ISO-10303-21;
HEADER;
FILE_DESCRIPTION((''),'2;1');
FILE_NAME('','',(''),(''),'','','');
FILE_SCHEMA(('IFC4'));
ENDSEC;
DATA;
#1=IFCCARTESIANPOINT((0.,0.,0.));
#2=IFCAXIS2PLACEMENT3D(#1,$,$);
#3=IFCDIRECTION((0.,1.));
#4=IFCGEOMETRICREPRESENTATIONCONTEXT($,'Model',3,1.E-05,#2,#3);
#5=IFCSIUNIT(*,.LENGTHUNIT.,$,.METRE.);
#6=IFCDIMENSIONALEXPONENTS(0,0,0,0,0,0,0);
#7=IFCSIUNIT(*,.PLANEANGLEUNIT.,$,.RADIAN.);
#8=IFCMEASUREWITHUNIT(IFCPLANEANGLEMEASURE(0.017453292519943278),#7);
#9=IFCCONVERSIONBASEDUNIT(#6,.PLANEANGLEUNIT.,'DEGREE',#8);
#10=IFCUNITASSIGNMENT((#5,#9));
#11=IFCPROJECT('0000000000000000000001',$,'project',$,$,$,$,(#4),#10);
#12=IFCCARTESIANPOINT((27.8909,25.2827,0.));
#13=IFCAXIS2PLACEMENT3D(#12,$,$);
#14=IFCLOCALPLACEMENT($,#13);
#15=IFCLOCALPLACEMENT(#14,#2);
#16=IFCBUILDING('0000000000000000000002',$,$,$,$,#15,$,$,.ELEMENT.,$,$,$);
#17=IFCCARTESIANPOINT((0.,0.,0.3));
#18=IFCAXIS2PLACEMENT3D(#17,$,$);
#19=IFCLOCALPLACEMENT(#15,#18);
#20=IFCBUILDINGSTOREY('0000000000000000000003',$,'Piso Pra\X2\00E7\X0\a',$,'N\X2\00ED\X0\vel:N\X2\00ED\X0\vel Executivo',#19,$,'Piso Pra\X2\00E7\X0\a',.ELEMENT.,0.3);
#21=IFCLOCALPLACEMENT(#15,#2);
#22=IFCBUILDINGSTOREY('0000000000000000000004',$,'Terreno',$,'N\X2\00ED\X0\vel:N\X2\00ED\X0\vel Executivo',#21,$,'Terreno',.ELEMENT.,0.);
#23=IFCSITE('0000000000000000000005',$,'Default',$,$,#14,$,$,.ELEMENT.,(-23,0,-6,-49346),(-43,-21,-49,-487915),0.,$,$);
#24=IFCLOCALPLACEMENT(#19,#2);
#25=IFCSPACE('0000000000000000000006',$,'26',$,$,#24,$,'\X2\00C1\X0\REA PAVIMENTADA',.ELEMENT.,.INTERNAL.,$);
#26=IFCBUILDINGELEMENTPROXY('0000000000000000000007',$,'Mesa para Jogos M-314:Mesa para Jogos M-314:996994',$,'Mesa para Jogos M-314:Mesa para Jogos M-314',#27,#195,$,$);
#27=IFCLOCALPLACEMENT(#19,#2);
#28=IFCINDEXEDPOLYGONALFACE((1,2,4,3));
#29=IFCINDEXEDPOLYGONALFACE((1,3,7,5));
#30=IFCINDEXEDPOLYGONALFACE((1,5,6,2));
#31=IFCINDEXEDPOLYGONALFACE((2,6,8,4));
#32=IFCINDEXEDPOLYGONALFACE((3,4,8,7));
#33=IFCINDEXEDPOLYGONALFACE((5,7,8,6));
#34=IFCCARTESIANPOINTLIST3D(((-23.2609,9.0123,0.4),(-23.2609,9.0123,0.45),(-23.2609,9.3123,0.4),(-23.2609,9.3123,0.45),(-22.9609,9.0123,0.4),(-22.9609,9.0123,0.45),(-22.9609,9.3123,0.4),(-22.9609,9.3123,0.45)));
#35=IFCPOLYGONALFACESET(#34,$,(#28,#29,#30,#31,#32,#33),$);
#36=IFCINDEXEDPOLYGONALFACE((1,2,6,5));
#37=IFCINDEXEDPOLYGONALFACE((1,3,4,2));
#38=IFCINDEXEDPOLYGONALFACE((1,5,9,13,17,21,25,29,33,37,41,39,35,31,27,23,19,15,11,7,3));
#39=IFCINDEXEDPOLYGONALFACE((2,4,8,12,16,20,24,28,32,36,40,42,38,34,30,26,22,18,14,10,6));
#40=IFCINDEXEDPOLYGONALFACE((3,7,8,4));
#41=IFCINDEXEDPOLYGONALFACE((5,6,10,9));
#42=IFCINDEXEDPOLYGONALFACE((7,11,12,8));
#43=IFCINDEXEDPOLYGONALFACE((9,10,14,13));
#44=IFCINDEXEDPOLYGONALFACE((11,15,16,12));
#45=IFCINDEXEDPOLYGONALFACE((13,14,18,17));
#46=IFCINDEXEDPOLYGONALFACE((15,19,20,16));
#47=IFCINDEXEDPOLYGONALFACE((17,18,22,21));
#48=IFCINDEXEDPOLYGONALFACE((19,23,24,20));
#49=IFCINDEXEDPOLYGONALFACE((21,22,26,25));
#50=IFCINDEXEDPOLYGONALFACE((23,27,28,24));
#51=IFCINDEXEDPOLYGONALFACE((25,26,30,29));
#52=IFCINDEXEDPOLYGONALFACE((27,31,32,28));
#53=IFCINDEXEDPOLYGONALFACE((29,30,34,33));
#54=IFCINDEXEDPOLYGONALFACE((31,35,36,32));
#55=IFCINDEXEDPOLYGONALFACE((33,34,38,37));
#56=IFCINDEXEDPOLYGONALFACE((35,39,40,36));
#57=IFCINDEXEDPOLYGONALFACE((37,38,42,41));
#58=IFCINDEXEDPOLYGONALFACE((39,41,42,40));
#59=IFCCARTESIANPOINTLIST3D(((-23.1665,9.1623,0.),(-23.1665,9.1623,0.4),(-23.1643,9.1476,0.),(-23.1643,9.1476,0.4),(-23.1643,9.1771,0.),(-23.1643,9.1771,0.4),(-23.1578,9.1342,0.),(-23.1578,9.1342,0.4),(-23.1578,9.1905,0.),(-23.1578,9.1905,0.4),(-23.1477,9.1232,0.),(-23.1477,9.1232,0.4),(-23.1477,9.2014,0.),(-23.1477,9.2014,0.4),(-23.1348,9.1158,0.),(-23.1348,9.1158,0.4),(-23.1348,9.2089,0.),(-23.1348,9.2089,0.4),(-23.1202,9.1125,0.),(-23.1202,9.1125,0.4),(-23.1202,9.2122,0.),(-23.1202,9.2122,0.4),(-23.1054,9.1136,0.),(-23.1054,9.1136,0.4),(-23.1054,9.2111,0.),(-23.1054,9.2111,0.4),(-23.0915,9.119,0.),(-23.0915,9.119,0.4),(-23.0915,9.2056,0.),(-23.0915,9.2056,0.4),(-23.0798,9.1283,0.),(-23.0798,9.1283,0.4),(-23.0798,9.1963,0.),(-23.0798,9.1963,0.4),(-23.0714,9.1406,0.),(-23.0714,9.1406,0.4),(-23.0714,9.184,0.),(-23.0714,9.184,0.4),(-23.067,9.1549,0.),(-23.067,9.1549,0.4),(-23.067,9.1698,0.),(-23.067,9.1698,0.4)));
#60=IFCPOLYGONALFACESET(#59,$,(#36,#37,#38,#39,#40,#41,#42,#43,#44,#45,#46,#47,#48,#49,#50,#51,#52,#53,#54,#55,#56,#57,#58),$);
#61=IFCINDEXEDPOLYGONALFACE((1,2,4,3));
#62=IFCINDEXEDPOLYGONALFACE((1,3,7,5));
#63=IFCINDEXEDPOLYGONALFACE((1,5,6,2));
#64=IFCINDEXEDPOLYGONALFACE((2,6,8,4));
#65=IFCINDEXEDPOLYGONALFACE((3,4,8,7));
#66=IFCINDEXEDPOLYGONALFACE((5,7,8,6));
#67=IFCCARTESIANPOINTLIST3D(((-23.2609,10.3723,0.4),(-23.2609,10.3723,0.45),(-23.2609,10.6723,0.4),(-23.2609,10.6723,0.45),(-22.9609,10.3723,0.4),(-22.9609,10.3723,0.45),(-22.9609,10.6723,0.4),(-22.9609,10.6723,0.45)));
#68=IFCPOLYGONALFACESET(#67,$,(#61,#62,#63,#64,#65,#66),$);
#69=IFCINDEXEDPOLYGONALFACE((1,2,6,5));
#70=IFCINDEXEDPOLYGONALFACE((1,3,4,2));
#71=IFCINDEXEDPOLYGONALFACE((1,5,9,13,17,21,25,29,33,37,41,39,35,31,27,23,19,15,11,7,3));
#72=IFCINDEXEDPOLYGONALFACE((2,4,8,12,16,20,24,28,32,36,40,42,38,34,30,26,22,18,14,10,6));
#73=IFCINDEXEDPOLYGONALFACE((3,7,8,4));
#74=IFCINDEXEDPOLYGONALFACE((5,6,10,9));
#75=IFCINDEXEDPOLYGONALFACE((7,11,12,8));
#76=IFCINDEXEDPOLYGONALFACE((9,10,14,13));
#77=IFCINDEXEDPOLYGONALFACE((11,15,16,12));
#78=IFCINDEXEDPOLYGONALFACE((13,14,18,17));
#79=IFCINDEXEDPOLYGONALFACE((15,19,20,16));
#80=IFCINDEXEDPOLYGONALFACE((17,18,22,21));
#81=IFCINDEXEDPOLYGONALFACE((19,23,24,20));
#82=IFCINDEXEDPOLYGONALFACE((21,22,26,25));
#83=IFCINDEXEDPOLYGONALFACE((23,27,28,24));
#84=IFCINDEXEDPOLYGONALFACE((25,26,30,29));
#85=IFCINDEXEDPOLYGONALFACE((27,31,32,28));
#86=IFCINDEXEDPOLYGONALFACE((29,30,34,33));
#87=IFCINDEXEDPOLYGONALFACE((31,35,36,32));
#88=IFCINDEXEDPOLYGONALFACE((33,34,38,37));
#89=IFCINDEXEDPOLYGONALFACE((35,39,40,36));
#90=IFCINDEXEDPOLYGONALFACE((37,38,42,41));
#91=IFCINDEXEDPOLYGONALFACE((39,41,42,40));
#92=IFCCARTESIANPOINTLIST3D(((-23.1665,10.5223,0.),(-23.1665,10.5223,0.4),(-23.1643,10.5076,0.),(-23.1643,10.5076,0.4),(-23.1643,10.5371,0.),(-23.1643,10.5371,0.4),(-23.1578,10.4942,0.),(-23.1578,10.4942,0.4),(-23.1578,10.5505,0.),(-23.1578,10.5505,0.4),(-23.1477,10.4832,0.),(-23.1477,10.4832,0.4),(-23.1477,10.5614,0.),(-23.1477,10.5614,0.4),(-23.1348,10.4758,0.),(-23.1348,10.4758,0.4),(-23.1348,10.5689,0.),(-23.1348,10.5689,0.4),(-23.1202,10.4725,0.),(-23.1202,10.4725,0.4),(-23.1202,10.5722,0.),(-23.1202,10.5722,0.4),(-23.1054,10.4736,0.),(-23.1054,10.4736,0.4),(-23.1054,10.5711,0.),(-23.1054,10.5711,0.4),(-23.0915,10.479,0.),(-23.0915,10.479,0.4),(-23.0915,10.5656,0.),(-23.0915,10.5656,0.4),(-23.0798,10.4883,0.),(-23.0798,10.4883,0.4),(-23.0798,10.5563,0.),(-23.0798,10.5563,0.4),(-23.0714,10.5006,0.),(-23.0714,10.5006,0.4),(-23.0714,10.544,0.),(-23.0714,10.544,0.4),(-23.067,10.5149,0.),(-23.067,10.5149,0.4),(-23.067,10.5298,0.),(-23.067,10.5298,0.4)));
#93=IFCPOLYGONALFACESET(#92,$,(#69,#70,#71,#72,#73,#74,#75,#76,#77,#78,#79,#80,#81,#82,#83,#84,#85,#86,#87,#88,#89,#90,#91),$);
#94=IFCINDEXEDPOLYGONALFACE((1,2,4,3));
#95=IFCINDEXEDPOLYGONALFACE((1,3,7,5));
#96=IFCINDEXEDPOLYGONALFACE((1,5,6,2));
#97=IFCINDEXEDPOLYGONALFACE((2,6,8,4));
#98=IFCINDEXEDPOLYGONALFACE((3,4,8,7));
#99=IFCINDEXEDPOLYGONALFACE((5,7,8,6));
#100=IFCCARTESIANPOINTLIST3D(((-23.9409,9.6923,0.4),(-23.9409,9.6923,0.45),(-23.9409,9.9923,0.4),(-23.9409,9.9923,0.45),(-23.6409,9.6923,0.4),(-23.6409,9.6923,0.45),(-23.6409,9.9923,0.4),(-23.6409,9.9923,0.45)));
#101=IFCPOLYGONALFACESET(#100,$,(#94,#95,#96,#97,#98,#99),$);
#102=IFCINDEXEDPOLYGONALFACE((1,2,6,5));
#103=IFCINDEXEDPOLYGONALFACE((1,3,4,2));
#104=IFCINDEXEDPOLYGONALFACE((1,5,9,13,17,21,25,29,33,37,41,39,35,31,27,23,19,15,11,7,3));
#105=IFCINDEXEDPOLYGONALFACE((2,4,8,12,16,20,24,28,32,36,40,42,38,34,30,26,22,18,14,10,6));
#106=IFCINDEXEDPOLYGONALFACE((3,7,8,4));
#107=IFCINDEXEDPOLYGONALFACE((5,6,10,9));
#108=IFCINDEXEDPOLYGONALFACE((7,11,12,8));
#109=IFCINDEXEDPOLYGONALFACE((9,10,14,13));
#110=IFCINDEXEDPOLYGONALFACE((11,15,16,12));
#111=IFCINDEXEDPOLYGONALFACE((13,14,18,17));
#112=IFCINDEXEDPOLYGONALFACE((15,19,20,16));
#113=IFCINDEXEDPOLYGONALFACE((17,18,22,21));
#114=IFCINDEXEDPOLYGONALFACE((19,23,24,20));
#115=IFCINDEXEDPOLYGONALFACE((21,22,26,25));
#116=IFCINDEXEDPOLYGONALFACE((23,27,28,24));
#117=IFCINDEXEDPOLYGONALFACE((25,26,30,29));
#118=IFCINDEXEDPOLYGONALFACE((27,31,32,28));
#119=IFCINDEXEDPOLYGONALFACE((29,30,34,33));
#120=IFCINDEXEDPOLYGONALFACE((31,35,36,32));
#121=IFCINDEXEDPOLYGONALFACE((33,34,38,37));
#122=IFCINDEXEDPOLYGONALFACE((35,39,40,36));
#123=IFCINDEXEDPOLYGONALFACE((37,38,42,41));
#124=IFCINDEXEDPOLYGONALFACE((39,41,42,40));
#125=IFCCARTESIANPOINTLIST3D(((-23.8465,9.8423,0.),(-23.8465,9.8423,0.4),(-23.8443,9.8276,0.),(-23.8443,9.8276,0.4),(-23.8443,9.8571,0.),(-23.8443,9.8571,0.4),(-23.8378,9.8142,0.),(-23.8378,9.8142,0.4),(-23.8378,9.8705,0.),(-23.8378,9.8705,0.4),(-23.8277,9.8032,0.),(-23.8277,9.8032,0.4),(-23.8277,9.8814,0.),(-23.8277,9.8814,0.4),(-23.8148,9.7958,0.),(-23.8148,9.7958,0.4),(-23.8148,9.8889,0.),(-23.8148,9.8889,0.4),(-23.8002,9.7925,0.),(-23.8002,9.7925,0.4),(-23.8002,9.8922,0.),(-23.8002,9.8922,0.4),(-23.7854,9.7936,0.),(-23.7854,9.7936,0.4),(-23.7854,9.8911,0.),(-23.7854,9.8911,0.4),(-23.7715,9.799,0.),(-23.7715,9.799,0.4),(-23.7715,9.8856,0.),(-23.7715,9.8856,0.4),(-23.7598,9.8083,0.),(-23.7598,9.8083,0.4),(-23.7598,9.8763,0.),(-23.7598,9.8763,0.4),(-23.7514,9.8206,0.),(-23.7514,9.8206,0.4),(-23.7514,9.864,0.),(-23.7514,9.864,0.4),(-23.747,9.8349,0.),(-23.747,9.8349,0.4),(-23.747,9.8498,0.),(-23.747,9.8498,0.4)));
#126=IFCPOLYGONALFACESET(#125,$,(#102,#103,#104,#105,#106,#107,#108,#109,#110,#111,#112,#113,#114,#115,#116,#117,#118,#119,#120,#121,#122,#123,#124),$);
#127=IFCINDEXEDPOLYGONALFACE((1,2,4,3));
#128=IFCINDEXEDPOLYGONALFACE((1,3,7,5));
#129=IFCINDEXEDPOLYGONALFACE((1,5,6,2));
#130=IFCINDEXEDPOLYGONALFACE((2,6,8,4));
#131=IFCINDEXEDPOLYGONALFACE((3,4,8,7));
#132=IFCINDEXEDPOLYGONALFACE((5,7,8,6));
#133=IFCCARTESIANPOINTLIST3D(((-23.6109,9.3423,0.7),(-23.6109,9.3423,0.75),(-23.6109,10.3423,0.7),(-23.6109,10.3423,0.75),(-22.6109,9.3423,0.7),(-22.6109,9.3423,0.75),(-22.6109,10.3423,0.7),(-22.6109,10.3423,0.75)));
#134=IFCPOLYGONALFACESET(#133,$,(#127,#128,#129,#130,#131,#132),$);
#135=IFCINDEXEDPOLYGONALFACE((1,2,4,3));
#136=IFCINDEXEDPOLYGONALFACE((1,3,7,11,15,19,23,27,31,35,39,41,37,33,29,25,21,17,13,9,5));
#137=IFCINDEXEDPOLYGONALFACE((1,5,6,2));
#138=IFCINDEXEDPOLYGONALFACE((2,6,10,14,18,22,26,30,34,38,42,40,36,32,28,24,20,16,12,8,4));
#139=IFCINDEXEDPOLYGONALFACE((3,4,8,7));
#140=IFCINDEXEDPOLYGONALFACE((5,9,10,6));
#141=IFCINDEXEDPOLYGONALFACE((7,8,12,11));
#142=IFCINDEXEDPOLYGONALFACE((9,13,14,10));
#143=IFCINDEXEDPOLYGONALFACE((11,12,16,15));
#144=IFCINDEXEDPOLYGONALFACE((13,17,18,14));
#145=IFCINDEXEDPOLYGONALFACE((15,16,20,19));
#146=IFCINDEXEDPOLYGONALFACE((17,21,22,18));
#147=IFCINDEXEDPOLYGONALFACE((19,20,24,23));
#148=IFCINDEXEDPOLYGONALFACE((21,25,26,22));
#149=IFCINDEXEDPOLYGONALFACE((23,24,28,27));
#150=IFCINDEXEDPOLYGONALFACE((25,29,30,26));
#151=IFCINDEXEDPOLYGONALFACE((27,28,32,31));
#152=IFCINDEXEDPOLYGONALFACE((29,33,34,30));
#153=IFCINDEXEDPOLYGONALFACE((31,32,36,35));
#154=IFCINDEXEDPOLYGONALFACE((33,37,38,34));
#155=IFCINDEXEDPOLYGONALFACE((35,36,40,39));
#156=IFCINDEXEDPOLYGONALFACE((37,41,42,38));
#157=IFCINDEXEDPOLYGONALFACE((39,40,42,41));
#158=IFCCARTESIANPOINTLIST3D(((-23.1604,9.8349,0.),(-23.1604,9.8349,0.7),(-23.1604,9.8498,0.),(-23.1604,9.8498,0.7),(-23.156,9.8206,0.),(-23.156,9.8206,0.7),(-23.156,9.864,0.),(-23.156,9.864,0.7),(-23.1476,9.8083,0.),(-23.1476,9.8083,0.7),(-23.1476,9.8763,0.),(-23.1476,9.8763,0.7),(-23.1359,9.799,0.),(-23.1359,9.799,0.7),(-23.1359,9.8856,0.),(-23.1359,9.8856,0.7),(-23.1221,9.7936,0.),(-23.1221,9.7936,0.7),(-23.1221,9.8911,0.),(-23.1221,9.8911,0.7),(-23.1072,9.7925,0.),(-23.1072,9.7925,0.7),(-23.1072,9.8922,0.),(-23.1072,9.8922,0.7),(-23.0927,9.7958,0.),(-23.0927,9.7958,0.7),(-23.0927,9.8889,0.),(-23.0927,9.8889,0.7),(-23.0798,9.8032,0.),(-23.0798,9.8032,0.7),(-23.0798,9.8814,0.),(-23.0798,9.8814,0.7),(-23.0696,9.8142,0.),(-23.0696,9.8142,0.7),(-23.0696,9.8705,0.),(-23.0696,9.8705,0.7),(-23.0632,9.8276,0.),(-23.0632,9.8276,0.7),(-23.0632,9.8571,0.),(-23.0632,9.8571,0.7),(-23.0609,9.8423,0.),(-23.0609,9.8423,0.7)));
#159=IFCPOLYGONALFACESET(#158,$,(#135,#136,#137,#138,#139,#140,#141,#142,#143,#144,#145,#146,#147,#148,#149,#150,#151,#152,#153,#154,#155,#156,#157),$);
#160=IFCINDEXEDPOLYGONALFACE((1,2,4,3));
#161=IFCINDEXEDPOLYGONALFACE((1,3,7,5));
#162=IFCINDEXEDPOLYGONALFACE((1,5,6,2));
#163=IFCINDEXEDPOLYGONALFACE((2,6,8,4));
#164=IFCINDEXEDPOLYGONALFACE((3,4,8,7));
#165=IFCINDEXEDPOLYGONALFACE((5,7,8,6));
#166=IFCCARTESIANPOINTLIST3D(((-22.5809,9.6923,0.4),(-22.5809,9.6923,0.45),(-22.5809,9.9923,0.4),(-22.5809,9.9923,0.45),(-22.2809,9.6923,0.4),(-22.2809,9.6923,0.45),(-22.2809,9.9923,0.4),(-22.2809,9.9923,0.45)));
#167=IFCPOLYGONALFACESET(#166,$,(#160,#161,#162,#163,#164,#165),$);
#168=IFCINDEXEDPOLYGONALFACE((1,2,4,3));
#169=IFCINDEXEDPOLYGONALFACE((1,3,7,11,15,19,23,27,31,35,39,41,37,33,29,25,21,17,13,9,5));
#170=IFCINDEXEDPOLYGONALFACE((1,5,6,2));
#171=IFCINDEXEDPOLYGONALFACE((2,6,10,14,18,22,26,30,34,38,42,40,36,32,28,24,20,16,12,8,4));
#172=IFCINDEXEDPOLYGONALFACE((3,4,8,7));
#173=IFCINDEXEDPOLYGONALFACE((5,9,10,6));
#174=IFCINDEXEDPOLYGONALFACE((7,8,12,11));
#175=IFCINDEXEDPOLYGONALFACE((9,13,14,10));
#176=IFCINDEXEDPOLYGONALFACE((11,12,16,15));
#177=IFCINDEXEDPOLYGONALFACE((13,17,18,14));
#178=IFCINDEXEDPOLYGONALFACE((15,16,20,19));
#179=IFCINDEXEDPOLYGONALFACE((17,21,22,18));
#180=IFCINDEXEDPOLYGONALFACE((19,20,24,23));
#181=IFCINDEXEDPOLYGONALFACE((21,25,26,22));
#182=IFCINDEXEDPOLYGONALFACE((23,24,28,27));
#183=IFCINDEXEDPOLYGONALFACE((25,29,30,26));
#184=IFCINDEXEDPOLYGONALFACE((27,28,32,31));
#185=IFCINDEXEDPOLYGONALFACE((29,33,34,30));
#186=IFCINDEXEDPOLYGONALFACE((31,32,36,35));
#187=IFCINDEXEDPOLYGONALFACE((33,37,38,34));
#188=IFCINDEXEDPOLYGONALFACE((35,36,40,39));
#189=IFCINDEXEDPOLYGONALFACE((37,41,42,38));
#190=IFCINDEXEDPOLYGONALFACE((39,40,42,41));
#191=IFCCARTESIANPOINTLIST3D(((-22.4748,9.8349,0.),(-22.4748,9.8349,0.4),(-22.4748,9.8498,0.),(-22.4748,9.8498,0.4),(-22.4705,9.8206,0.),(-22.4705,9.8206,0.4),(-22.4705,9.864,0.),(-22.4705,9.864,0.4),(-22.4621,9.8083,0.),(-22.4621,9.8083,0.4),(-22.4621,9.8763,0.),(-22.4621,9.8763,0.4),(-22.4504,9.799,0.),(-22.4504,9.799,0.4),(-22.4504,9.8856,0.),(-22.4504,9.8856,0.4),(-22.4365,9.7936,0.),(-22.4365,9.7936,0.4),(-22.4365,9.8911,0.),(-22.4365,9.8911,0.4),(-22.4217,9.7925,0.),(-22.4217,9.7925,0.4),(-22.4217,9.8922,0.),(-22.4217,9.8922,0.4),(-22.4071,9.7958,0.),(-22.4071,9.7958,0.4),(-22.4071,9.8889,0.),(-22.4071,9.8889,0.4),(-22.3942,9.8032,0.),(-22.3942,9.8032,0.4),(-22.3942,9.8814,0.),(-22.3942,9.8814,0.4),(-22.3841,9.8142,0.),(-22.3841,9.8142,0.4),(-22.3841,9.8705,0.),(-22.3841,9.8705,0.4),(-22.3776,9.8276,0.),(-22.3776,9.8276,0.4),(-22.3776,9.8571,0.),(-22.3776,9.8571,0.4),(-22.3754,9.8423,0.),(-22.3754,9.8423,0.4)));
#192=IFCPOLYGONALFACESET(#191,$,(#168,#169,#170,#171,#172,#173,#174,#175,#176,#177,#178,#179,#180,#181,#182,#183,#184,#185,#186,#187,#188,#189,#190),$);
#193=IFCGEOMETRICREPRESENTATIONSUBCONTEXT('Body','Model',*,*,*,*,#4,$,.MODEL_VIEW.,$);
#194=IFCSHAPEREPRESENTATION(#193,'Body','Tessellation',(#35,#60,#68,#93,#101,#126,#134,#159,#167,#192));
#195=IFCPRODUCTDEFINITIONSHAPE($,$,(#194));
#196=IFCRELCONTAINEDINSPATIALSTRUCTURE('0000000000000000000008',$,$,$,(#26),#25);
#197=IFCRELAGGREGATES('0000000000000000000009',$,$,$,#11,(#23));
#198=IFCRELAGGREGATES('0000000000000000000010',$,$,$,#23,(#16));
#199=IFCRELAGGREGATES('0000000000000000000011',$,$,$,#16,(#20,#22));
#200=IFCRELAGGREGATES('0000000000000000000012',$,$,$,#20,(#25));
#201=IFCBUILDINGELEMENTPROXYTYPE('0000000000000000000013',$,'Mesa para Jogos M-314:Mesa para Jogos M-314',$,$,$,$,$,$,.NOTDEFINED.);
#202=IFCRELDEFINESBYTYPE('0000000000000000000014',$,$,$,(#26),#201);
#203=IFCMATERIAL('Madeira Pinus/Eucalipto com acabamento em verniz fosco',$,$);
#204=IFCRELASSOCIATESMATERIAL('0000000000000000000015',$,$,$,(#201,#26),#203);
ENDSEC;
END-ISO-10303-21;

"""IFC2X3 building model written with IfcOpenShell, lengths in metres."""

from ifc_helpers import new_model, entity, si_unit, converted_unit, direction, frame, frame_2d, origin, place, context, subcontext, project, spatial, rectangle, circle, extrude, source, transform, mapped, material, type_object, type_shapes, element, save


model = new_model("IFC2X3")

# Units and contexts
model_context = context("Model", 3, precision=1e-05, world=origin(), true_north=direction((0.0, 1.0)))
body_context = subcontext(model_context, "Body", "Model", "MODEL_VIEW")
ifc_project = project(units=[si_unit("LENGTHUNIT", "METRE"), converted_unit("PLANEANGLEUNIT", "DEGREE", entity("IfcPlaneAngleMeasure", 0.017453292519943278), si_unit("PLANEANGLEUNIT", "RADIAN"), dimensions=[0, 0, 0, 0, 0, 0, 0])], contexts=[model_context])

# Site, building, storey
site_placement = place(None, frame((27.8909, 25.2827, 0.0)))
site = spatial("IfcSite", under=ifc_project, at=site_placement, Name="Default", CompositionType="ELEMENT", RefLatitude=(-23, 0, -6, -49346), RefLongitude=(-43, -21, -49, -487915), RefElevation=0.0)
building_placement = place(site_placement, origin())
building = spatial("IfcBuilding", under=site, at=building_placement, CompositionType="ELEMENT")
storey_1_placement = place(building_placement, frame((0.0, 0.0, 0.3)))
storey_1 = spatial("IfcBuildingStorey", under=building, at=storey_1_placement, Name="Piso Praça", ObjectType="Nível:Nível Executivo", LongName="Piso Praça", CompositionType="ELEMENT", Elevation=0.3)

# Shared definitions
ifc_material_1 = material(Name="Madeira Pinus/Eucalipto com acabamento em verniz fosco")

# Shared definitions
space_1_placement = place(storey_1_placement, origin())
space_1 = spatial("IfcSpace", under=storey_1, at=space_1_placement, Name="26", LongName="ÁREA PAVIMENTADA", CompositionType="ELEMENT", InteriorOrExteriorSpace="INTERNAL")

# Building element proxy
building_element_proxy_type_1 = type_object("IfcBuildingElementProxyType", Name="Mesa para Jogos M-314:Mesa para Jogos M-314", PredefinedType="NOTDEFINED", material=ifc_material_1)
shared_shape_1 = source(origin(), body_context, "Body", "SweptSolid", [
    extrude(rectangle(XDim=0.3, YDim=0.3, at=frame_2d((0.0, 0.0), x_axis=(1.0, 0.0))), frame((0.0, -0.68, 0.4)), (0.0, 0.0, 1.0), 0.05),
    extrude(circle(Radius=0.05, at=frame_2d((0.0, 0.0), x_axis=(1.0, 0.0))), frame((-0.0055, -0.68, 0.0), z_axis=(0.0, 0.0, 1.0), x_axis=(-1.0, 0.0, 0.0)), (0.0, 0.0, 1.0), 0.4),
    extrude(rectangle(XDim=0.3, YDim=0.3, at=frame_2d((0.0, 0.0), x_axis=(1.0, 0.0))), frame((0.0, 0.68, 0.4), z_axis=(0.0, 0.0, 1.0), x_axis=(0.0, -1.0, 0.0)), (0.0, 0.0, 1.0), 0.05),
    extrude(circle(Radius=0.05, at=frame_2d((0.0, 0.0), x_axis=(1.0, 0.0))), frame((-0.0055, 0.68, 0.0), z_axis=(0.0, 0.0, 1.0), x_axis=(-1.0, 0.0, 0.0)), (0.0, 0.0, 1.0), 0.4),
    extrude(rectangle(XDim=0.3, YDim=0.3, at=frame_2d((0.0, 0.0), x_axis=(1.0, 0.0))), frame((-0.68, 0.0, 0.4), z_axis=(0.0, 0.0, 1.0), x_axis=(0.0, -1.0, 0.0)), (0.0, 0.0, 1.0), 0.05),
    extrude(circle(Radius=0.05, at=frame_2d((0.0, 0.0), x_axis=(1.0, 0.0))), frame((-0.6855, 0.0, 0.0), z_axis=(0.0, 0.0, 1.0), x_axis=(-1.0, 0.0, 0.0)), (0.0, 0.0, 1.0), 0.4),
    extrude(rectangle(XDim=1.0, YDim=1.0, at=frame_2d((0.0, 0.0), x_axis=(1.0, 0.0))), frame((0.0, 0.0, 0.7), z_axis=(0.0, 0.0, 1.0), x_axis=(-1.0, 0.0, 0.0)), (0.0, 0.0, 1.0), 0.05),
    extrude(circle(Radius=0.05, at=frame_2d((0.0, 0.0), x_axis=(1.0, 0.0))), origin(), (0.0, 0.0, 1.0), 0.7),
    extrude(rectangle(XDim=0.3, YDim=0.3, at=frame_2d((0.0, 0.0), x_axis=(1.0, 0.0))), frame((0.68, 0.0, 0.4), z_axis=(0.0, 0.0, 1.0), x_axis=(-1.0, 0.0, 0.0)), (0.0, 0.0, 1.0), 0.05),
    extrude(circle(Radius=0.05, at=frame_2d((0.0, 0.0), x_axis=(1.0, 0.0))), frame((0.6855, 0.0, 0.0)), (0.0, 0.0, 1.0), 0.4),
])
type_shapes(building_element_proxy_type_1, [shared_shape_1])
for number, where, name in (
    (1, (-23.1109, 9.8423, 0.0), "Mesa para Jogos M-314:Mesa para Jogos M-314:996994"),
):
    element("IfcBuildingElementProxy", number, at=place(space_1_placement, frame(where)), inside=space_1, type_object=building_element_proxy_type_1, material=ifc_material_1, Name=name, ObjectType="Mesa para Jogos M-314:Mesa para Jogos M-314", context=body_context, shape_type="MappedRepresentation", body=[
        mapped(shared_shape_1, transform((0.0, 0.0, 0.0), scale=1.0)),
    ])

# Shared definitions
storey_2_placement = place(building_placement, origin())
storey_2 = spatial("IfcBuildingStorey", under=building, at=storey_2_placement, Name="Terreno", ObjectType="Nível:Nível Executivo", LongName="Terreno", CompositionType="ELEMENT", Elevation=0.0)

save(model, "model.ifc")
